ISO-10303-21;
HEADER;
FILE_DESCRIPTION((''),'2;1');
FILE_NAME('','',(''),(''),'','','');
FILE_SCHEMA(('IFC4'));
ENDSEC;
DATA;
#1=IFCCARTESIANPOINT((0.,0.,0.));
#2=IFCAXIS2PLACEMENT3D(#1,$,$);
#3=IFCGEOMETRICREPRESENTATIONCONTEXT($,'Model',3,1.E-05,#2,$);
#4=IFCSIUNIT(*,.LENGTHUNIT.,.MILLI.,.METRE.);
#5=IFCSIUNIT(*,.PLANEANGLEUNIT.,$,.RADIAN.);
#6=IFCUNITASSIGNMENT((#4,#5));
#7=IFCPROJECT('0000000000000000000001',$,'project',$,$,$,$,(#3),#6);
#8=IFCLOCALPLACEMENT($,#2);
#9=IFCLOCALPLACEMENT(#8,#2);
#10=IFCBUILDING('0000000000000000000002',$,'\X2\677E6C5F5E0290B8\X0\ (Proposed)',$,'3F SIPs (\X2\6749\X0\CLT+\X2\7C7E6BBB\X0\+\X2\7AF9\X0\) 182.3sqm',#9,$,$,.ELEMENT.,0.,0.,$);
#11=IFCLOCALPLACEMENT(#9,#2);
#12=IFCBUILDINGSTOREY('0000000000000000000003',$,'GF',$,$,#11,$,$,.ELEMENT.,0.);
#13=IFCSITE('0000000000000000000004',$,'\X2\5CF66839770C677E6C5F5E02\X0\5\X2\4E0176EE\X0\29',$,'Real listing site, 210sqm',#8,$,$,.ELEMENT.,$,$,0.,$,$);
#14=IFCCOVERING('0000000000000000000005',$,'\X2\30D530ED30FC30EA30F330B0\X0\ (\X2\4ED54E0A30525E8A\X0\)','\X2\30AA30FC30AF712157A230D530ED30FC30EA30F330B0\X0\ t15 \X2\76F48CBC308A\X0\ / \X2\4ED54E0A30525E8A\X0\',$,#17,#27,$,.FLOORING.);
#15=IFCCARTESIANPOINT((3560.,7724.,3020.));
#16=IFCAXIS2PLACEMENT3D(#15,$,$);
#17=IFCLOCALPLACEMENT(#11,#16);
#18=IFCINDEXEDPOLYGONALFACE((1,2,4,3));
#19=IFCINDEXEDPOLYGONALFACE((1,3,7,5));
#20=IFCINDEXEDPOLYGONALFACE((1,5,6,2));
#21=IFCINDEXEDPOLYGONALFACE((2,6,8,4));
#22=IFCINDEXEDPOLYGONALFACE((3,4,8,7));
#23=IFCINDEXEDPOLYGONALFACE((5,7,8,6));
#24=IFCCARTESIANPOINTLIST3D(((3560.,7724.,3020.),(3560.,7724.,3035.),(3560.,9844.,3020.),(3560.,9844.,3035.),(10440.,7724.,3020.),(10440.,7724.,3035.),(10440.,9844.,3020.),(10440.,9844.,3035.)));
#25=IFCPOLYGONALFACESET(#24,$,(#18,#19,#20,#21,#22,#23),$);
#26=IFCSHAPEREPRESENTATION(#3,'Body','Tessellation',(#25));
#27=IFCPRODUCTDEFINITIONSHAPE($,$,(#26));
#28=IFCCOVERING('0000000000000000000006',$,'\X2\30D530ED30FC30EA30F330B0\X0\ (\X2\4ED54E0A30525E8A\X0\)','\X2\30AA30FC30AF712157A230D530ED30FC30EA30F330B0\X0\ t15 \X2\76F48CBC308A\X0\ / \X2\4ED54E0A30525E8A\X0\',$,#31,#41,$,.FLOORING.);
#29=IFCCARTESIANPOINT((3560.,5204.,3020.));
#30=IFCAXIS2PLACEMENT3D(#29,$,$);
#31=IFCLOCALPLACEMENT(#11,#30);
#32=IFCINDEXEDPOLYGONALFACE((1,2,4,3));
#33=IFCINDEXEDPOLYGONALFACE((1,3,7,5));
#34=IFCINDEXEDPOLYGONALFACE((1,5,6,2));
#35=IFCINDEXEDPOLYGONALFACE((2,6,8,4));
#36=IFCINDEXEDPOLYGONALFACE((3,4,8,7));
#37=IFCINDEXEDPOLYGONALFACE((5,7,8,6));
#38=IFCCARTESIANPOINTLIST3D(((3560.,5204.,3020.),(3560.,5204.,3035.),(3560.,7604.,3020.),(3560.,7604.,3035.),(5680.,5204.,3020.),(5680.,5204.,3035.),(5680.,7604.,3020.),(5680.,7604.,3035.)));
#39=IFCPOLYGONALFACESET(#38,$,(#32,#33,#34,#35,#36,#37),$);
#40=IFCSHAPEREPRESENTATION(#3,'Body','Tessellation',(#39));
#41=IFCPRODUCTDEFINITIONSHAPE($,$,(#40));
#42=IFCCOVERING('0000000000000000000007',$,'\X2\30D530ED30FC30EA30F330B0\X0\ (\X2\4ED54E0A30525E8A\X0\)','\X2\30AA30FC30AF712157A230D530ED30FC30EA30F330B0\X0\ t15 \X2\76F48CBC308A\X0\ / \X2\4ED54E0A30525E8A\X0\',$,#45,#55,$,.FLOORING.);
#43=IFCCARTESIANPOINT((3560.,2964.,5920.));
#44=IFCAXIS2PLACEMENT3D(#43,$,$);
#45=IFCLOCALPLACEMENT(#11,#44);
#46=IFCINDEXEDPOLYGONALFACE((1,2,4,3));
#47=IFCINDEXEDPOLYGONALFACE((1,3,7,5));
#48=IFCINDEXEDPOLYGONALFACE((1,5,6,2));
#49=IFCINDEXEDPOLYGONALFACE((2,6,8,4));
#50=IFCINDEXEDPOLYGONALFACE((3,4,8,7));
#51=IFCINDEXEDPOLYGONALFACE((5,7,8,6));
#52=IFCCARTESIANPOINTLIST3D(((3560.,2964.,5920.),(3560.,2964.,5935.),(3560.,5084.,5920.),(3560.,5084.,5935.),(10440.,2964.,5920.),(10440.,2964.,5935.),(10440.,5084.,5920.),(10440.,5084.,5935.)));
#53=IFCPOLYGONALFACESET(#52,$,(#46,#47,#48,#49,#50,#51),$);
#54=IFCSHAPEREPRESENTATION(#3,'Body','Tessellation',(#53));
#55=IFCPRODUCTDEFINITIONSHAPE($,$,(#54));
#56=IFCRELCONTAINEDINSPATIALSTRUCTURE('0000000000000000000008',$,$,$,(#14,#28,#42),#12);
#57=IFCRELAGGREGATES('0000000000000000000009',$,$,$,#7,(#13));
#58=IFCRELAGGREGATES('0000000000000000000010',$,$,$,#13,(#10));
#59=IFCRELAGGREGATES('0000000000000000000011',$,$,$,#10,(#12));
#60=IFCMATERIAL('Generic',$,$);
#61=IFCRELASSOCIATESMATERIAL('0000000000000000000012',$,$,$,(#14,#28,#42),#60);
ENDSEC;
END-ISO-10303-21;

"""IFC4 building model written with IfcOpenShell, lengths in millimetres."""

from ifc_helpers import new_model, si_unit, frame, frame_2d, origin, place, context, project, spatial, rectangle, extrude, material, element, save


model = new_model("IFC4")

# Units and contexts
model_context = context("Model", 3, precision=1e-05, world=origin())
ifc_project = project(units=[si_unit("LENGTHUNIT", "METRE", prefix="MILLI"), si_unit("PLANEANGLEUNIT", "RADIAN")], contexts=[model_context])

# Site, building, storey
site_placement = place(None, origin())
site = spatial("IfcSite", under=ifc_project, at=site_placement, Name="島根県松江市5丁目29", ObjectType="Real listing site, 210sqm", CompositionType="ELEMENT", RefElevation=0.0)
building_placement = place(site_placement, origin())
building = spatial("IfcBuilding", under=site, at=building_placement, Name="松江市邸 (Proposed)", ObjectType="3F SIPs (杉CLT+籾殻+竹) 182.3sqm", CompositionType="ELEMENT", ElevationOfRefHeight=0.0, ElevationOfTerrain=0.0)
storey_placement = place(building_placement, origin())
storey = spatial("IfcBuildingStorey", under=building, at=storey_placement, Name="GF", CompositionType="ELEMENT", Elevation=0.0)

# Shared definitions
ifc_material_1 = material(Name="Generic")

# Coverings
covering_1_placement = place(storey_placement, frame((3560.0, 7724.0, 3020.0)))
element("IfcCovering", 1, at=covering_1_placement, inside=storey, material=ifc_material_1, Name="フローリング (仕上げ床)", Description="オーク無垢フローリング t15 直貼り / 仕上げ床", PredefinedType="FLOORING", context=model_context, shape_type="SweptSolid", body=[
    extrude(rectangle(XDim=6880.0, YDim=2120.0, at=frame_2d((3440.0, 1060.0))), frame((3560.0, 7724.0, 3020.0)), (0.0, 0.0, 1.0), 15.0),
])
covering_2_placement = place(storey_placement, frame((3560.0, 5204.0, 3020.0)))
element("IfcCovering", 2, at=covering_2_placement, inside=storey, material=ifc_material_1, Name="フローリング (仕上げ床)", Description="オーク無垢フローリング t15 直貼り / 仕上げ床", PredefinedType="FLOORING", context=model_context, shape_type="SweptSolid", body=[
    extrude(rectangle(XDim=2120.0, YDim=2400.0, at=frame_2d((1060.0, 1200.0))), frame((3560.0, 5204.0, 3020.0)), (0.0, 0.0, 1.0), 15.0),
])
covering_3_placement = place(storey_placement, frame((3560.0, 2964.0, 5920.0)))
element("IfcCovering", 3, at=covering_3_placement, inside=storey, material=ifc_material_1, Name="フローリング (仕上げ床)", Description="オーク無垢フローリング t15 直貼り / 仕上げ床", PredefinedType="FLOORING", context=model_context, shape_type="SweptSolid", body=[
    extrude(rectangle(XDim=6880.0, YDim=2120.0, at=frame_2d((3440.0, 1060.0))), frame((3560.0, 2964.0, 5920.0)), (0.0, 0.0, 1.0), 15.0),
])

save(model, "model.ifc")
